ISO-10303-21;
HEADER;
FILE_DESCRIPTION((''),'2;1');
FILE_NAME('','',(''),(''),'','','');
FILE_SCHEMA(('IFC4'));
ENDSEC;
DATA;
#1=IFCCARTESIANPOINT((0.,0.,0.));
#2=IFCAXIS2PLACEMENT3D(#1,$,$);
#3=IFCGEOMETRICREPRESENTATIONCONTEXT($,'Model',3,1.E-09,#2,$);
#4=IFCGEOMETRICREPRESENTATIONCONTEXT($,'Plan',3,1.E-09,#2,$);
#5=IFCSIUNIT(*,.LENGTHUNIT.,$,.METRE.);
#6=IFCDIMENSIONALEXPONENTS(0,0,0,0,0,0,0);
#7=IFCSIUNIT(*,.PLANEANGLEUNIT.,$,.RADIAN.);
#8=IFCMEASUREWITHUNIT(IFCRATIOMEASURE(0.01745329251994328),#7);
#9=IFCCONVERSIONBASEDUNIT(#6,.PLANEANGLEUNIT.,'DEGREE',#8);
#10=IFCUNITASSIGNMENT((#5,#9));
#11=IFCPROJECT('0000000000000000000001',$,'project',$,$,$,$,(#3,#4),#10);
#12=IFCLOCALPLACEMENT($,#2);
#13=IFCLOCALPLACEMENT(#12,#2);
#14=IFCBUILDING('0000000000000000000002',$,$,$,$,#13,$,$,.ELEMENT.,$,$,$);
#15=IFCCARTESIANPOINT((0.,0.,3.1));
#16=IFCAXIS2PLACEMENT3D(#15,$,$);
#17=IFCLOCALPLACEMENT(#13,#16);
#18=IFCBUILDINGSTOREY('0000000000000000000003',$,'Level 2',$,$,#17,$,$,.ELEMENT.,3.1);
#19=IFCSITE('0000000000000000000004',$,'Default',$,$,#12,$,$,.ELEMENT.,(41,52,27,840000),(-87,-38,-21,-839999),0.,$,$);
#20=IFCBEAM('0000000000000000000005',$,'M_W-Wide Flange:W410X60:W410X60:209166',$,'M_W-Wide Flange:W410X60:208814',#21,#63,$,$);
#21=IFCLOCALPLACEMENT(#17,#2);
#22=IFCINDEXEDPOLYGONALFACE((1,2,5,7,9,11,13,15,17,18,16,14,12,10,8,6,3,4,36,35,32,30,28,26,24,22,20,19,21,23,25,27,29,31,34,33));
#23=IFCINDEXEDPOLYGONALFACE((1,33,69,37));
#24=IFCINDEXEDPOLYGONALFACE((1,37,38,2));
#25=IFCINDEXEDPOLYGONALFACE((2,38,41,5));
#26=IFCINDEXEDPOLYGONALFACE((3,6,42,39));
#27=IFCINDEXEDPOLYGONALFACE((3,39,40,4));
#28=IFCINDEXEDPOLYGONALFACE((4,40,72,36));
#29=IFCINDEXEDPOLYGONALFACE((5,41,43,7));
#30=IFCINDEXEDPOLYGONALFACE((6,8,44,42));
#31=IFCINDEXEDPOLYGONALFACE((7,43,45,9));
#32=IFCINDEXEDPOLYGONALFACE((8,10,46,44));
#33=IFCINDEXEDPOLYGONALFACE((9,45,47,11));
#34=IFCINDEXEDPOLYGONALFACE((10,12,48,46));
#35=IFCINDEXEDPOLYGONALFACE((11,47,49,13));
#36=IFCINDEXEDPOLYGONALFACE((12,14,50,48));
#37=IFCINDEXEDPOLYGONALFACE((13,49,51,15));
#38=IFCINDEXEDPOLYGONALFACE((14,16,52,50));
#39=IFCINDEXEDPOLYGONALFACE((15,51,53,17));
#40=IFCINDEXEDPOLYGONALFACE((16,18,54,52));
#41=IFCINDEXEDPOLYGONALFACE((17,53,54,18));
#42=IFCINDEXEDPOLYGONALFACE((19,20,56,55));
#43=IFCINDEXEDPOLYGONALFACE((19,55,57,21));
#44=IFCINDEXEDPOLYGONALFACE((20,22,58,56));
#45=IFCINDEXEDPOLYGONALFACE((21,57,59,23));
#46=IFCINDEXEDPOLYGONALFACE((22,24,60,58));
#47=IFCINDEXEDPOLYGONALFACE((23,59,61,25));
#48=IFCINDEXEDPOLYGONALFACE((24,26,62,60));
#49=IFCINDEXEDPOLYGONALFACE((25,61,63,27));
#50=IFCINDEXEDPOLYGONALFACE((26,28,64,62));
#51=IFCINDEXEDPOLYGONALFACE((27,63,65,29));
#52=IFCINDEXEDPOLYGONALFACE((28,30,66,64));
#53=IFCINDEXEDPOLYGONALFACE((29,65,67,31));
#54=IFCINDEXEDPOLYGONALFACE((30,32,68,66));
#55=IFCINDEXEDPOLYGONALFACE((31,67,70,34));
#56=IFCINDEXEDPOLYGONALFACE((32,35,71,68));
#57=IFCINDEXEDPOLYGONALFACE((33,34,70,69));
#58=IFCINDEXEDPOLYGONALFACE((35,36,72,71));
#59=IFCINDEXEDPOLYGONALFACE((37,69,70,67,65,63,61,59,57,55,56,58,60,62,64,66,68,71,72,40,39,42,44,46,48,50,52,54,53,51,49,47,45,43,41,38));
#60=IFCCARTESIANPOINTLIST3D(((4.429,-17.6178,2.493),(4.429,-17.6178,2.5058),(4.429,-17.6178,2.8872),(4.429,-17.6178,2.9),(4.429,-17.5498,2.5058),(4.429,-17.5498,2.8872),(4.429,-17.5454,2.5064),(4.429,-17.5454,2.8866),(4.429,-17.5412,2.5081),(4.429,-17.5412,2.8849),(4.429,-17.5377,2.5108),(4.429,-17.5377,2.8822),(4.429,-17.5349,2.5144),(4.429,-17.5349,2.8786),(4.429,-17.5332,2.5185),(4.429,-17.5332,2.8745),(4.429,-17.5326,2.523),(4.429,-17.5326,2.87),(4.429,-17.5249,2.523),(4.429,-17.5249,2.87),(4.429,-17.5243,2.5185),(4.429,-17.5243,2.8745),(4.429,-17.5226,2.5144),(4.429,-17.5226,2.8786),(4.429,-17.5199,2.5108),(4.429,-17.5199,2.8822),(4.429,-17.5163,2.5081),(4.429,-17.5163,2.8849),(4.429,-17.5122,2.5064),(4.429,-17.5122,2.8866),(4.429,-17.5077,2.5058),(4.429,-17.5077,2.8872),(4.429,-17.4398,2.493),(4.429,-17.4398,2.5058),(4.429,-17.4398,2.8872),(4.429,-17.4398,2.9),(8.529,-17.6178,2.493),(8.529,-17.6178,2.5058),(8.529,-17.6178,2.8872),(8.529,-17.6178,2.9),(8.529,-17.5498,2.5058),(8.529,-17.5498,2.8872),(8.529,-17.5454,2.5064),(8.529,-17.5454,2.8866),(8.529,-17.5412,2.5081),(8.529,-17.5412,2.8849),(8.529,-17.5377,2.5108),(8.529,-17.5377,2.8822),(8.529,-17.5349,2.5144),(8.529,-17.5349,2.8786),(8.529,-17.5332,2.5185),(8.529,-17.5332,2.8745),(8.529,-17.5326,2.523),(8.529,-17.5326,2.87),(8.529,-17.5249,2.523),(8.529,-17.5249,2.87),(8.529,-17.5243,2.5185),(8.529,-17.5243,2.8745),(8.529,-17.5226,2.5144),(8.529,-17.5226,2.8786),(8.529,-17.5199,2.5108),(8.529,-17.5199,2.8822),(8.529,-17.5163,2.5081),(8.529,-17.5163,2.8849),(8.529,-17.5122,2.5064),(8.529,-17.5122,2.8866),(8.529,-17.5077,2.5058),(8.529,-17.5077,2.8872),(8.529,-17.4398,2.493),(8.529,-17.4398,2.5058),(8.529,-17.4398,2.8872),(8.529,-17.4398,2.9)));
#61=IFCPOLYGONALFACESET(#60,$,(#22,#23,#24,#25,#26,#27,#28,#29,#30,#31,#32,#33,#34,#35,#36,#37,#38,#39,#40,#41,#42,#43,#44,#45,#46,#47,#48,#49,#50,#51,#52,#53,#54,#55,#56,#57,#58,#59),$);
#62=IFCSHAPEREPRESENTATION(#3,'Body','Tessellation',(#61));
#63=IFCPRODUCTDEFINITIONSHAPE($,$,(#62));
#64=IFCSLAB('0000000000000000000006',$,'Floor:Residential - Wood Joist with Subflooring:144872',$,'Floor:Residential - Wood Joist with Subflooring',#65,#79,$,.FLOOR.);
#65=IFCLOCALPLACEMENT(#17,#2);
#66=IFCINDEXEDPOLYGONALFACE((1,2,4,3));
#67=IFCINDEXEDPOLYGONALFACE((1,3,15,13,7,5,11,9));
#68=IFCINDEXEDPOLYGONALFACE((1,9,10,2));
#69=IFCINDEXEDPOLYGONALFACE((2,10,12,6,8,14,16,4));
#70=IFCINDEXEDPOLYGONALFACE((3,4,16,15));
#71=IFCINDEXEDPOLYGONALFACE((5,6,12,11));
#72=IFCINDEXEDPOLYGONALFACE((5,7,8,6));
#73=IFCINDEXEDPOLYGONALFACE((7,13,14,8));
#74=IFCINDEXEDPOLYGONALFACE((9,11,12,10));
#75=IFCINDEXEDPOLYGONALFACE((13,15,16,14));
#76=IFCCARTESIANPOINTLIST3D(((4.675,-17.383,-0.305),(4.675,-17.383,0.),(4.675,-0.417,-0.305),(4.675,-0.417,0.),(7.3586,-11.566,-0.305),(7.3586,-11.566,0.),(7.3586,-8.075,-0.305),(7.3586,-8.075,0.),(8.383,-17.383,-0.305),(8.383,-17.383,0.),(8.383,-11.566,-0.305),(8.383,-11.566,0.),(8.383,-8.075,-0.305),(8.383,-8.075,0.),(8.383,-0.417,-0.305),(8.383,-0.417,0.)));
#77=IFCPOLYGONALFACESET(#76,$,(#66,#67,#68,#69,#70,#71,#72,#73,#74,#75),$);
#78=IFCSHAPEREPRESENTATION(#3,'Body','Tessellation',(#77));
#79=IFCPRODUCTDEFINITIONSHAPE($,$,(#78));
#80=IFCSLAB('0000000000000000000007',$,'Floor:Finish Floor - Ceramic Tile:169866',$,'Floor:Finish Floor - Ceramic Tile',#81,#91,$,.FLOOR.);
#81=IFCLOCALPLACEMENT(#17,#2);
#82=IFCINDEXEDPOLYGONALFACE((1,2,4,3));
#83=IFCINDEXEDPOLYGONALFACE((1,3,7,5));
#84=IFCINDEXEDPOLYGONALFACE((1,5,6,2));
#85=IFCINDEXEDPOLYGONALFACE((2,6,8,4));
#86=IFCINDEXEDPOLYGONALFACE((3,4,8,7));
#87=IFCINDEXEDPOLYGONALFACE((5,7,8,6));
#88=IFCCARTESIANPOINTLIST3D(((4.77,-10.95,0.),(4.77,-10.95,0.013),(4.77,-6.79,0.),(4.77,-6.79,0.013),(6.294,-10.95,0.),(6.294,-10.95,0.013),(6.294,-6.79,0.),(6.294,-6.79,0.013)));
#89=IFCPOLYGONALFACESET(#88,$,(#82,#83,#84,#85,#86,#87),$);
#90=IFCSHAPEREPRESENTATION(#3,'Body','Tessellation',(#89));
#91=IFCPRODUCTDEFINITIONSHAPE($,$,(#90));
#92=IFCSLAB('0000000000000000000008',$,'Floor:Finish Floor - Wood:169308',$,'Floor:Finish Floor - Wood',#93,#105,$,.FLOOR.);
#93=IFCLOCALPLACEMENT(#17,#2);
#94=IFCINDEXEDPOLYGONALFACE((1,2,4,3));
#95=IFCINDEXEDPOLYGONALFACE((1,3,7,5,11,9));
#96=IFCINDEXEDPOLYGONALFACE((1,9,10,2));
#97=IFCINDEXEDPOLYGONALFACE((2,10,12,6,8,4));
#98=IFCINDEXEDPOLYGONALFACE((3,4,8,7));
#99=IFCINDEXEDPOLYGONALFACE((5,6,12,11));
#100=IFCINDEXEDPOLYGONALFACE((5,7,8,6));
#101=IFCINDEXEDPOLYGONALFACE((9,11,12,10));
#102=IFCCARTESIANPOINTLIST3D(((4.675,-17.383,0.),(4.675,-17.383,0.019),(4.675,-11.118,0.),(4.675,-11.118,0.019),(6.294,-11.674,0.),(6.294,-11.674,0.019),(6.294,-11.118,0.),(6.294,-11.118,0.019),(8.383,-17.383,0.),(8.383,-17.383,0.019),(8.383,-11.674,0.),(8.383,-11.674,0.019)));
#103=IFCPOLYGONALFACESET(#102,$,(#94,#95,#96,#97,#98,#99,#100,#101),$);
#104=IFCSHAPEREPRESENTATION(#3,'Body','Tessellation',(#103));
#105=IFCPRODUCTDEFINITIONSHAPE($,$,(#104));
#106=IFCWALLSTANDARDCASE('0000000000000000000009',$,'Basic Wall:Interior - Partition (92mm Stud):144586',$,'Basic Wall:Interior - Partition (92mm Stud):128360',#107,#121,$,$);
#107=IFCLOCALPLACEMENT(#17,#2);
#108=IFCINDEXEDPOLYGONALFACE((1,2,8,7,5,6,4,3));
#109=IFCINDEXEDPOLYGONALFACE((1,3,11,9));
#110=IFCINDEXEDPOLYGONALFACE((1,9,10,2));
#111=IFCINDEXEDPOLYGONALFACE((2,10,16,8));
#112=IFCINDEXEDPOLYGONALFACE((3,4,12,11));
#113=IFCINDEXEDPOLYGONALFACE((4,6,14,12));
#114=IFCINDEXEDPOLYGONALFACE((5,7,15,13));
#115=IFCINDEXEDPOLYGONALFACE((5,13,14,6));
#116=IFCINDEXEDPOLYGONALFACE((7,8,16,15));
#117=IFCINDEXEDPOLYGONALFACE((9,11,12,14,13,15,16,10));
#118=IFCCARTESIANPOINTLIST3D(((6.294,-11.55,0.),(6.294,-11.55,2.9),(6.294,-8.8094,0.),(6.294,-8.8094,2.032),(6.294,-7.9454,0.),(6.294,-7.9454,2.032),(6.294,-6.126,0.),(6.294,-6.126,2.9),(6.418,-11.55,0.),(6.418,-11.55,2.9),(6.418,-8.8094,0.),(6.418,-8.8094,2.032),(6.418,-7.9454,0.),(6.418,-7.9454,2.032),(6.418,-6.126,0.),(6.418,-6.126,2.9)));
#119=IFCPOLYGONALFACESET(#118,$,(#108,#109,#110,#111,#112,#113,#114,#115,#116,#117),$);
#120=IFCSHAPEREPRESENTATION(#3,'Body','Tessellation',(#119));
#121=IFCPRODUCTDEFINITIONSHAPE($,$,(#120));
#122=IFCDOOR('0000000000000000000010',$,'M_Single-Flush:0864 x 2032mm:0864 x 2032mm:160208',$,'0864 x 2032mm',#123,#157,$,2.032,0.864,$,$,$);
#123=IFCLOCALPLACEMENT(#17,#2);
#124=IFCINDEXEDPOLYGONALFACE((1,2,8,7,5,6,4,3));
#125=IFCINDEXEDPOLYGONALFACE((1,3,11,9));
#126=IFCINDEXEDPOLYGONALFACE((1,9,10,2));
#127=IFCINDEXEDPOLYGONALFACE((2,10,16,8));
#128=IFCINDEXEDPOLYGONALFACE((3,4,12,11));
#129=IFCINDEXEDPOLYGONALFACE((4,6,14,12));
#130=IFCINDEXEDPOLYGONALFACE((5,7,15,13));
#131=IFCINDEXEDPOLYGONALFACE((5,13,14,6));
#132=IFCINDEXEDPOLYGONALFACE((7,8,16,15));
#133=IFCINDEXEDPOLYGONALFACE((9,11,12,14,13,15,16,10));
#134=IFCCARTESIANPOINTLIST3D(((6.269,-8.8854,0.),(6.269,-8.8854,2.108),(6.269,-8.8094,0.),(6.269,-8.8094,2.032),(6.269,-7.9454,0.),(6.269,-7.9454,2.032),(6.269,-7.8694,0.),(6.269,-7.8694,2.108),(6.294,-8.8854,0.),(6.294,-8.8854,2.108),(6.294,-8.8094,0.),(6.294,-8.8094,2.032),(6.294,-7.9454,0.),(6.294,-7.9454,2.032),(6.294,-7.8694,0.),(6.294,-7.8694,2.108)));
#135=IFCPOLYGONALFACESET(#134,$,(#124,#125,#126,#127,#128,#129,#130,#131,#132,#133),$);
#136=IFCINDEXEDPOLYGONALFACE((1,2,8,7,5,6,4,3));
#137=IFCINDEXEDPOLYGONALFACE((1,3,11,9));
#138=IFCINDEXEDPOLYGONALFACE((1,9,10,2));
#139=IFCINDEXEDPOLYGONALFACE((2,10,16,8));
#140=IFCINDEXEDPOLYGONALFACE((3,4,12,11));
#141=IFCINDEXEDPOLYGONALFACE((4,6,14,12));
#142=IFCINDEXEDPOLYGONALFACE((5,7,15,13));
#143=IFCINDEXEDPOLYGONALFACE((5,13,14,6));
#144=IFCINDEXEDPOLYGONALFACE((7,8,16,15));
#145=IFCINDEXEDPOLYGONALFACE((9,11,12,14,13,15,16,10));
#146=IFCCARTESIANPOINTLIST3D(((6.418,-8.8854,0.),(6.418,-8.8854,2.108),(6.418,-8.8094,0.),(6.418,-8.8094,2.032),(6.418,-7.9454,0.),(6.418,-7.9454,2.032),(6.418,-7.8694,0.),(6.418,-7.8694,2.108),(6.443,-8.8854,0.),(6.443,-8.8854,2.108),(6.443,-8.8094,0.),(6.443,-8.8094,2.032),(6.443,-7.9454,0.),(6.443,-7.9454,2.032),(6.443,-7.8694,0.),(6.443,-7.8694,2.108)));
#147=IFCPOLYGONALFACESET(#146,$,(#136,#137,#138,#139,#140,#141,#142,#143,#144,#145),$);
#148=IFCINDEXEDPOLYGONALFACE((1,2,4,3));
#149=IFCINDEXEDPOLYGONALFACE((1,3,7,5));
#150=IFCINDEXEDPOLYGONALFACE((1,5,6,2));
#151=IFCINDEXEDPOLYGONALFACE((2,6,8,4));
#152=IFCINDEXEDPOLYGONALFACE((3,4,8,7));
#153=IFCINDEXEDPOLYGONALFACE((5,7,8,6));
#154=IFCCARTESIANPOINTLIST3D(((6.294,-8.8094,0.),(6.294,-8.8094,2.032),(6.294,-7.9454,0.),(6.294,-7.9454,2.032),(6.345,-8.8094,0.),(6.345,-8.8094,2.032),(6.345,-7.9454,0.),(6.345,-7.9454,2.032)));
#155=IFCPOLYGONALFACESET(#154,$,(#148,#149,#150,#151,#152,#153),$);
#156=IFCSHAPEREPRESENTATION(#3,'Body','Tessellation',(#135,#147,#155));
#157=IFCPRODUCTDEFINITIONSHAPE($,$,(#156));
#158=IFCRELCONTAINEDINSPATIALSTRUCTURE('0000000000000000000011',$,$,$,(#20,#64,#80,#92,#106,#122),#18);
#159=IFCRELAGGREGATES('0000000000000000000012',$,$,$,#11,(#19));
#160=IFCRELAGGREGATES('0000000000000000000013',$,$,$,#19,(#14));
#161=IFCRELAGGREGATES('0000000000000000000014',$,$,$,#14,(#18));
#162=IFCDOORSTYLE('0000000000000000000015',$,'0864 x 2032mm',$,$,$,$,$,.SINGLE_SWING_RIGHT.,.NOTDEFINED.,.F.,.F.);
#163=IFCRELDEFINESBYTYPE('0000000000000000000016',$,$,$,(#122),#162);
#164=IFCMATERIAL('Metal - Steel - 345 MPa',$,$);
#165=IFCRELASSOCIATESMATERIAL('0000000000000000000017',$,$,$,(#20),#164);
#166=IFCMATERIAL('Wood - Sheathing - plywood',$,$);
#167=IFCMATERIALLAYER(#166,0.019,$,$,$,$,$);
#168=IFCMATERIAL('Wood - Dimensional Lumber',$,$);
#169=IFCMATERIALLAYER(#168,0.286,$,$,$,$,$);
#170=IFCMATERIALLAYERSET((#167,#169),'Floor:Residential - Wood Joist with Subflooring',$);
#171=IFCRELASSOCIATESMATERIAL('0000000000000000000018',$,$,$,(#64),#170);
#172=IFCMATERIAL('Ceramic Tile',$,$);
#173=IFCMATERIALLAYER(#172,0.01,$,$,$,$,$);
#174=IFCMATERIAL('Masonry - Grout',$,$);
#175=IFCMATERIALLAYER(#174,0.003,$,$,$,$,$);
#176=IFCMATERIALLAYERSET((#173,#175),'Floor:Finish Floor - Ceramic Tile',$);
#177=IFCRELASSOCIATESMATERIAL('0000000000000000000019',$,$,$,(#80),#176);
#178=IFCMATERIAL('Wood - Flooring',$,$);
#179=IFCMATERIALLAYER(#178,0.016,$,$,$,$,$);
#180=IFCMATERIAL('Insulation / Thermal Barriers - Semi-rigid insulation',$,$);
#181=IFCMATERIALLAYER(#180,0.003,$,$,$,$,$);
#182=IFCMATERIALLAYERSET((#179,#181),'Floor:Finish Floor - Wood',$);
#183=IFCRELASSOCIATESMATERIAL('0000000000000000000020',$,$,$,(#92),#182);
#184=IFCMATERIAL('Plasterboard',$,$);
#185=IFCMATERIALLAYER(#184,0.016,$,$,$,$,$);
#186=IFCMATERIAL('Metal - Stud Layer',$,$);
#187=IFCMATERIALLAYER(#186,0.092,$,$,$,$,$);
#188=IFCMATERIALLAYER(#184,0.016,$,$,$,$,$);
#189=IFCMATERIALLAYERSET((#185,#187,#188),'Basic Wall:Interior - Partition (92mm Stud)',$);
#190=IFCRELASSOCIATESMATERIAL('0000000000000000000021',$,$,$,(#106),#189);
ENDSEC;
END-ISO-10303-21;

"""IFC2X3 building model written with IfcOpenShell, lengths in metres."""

from ifc_helpers import new_model, entity, si_unit, converted_unit, frame, frame_2d, origin, origin_2d_with_axis, place, context, project, spatial, polyline, circle_curve, parameter, trimmed, segment, composite_curve, rectangle, outline, extrude, source, transform, mapped, material, layer, layer_set, layer_usage, type_object, type_shapes, element, fill, save


model = new_model("IFC2X3")

# Units and contexts
model_context = context("Model", 3, precision=1e-09, world=origin())
plan_context = context("Plan", 3, precision=1e-09, world=origin())
ifc_project = project(units=[si_unit("LENGTHUNIT", "METRE"), converted_unit("PLANEANGLEUNIT", "DEGREE", entity("IfcRatioMeasure", 0.01745329251994328), si_unit("PLANEANGLEUNIT", "RADIAN"), dimensions=[0, 0, 0, 0, 0, 0, 0])], contexts=[model_context, plan_context])

# Site, building, storey
site_placement = place(None, origin())
site = spatial("IfcSite", under=ifc_project, at=site_placement, Name="Default", CompositionType="ELEMENT", RefLatitude=(41, 52, 27, 840000), RefLongitude=(-87, -38, -21, -839999), RefElevation=0.0)
building_placement = place(site_placement, origin())
building = spatial("IfcBuilding", under=site, at=building_placement, CompositionType="ELEMENT")
storey_placement = place(building_placement, frame((0.0, 0.0, 3.1)))
storey = spatial("IfcBuildingStorey", under=building, at=storey_placement, Name="Level 2", CompositionType="ELEMENT", Elevation=3.1)

# Beam
ifc_material_1 = material(Name="Metal - Steel - 345 MPa")
beam_placement = place(storey_placement, frame((4.429, -17.5288, 2.9), z_axis=(0.0, 0.0, 1.0), x_axis=(0.0, -1.0, 0.0)))
element("IfcBeam", 1, at=beam_placement, inside=storey, material=ifc_material_1, Name="M_W-Wide Flange:W410X60:W410X60:209166", ObjectType="M_W-Wide Flange:W410X60:208814", context=model_context, shape_type="SweptSolid", body=[
    extrude(outline(composite_curve([segment(polyline([(-0.089, -0.1907), (-0.089, -0.2035)]), True, "CONTINUOUS"), segment(polyline([(-0.089, -0.2035), (0.089, -0.2035)]), True, "CONTINUOUS"), segment(polyline([(0.089, -0.2035), (0.089, -0.1907)]), True, "CONTINUOUS"), segment(polyline([(0.089, -0.1907), (0.021, -0.1907)]), True, "CONTINUOUS"), segment(trimmed(circle_curve(frame_2d((0.021, -0.1735), x_axis=(0.0, -1.0)), 0.0172), [parameter(270.0)], [parameter(360.0)], True, "PARAMETER"), False, "CONTINUOUS"), segment(polyline([(0.0038, -0.1735), (0.0038, 0.1735)]), True, "CONTINUOUS"), segment(trimmed(circle_curve(frame_2d((0.021, 0.1735), x_axis=(-1.0, 0.0)), 0.0172), [parameter(270.0)], [parameter(360.0)], True, "PARAMETER"), False, "CONTINUOUS"), segment(polyline([(0.021, 0.1907), (0.089, 0.1907)]), True, "CONTINUOUS"), segment(polyline([(0.089, 0.1907), (0.089, 0.2035)]), True, "CONTINUOUS"), segment(polyline([(0.089, 0.2035), (-0.089, 0.2035)]), True, "CONTINUOUS"), segment(polyline([(-0.089, 0.2035), (-0.089, 0.1907)]), True, "CONTINUOUS"), segment(polyline([(-0.089, 0.1907), (-0.0211, 0.1907)]), True, "CONTINUOUS"), segment(trimmed(circle_curve(frame_2d((-0.0211, 0.1735), x_axis=(0.0, 1.0)), 0.0172), [parameter(270.0)], [parameter(0.0)], True, "PARAMETER"), False, "CONTINUOUS"), segment(polyline([(-0.0039, 0.1735), (-0.0039, -0.1735)]), True, "CONTINUOUS"), segment(trimmed(circle_curve(frame_2d((-0.0211, -0.1735), x_axis=(1.0, 0.0)), 0.0172), [parameter(270.0)], [parameter(0.0)], True, "PARAMETER"), False, "CONTINUOUS"), segment(polyline([(-0.0211, -0.1907), (-0.089, -0.1907)]), True, "CONTINUOUS")], self_intersect=False)), frame((0.0, 0.0, -0.2035), z_axis=(0.0, -1.0, 0.0), x_axis=(1.0, 0.0, 0.0)), (0.0, 0.0, -1.0), 4.1),
])

# Slabs
ifc_material_2 = material(Name="Wood - Sheathing - plywood")
ifc_layer_1 = layer(ifc_material_2, 0.019)
ifc_material_3 = material(Name="Wood - Dimensional Lumber")
ifc_layer_2 = layer(ifc_material_3, 0.286)
ifc_layer_set_1 = layer_set([ifc_layer_1, ifc_layer_2], Name="Floor:Residential - Wood Joist with Subflooring")
ifc_layer_usage_1 = layer_usage(ifc_layer_set_1, "AXIS3", "POSITIVE", 0.0)
slab_1_placement = place(storey_placement, frame((4.675, -17.383, -0.305)))
element("IfcSlab", 2, at=slab_1_placement, inside=storey, material=ifc_layer_usage_1, Name="Floor:Residential - Wood Joist with Subflooring:144872", ObjectType="Floor:Residential - Wood Joist with Subflooring", PredefinedType="FLOOR", context=model_context, shape_type="SweptSolid", body=[
    extrude(outline(polyline([(-1.854, 8.483), (-1.854, 0.825), (-0.8296, 0.825), (-0.8296, -2.666), (-1.854, -2.666), (-1.854, -8.483), (1.854, -8.483), (1.854, 8.483), (-1.854, 8.483)])), frame((1.854, 8.483, 0.305), z_axis=(0.0, 0.0, -1.0), x_axis=(-1.0, 0.0, 0.0)), (0.0, 0.0, 1.0), 0.305),
])
ifc_material_4 = material(Name="Ceramic Tile")
ifc_layer_3 = layer(ifc_material_4, 0.01)
ifc_material_5 = material(Name="Masonry - Grout")
ifc_layer_4 = layer(ifc_material_5, 0.003)
ifc_layer_set_2 = layer_set([ifc_layer_3, ifc_layer_4], Name="Floor:Finish Floor - Ceramic Tile")
ifc_layer_usage_2 = layer_usage(ifc_layer_set_2, "AXIS3", "POSITIVE", 0.0)
slab_2_placement = place(storey_placement, frame((4.77, -10.95, 0.0)))
element("IfcSlab", 3, at=slab_2_placement, inside=storey, material=ifc_layer_usage_2, Name="Floor:Finish Floor - Ceramic Tile:169866", ObjectType="Floor:Finish Floor - Ceramic Tile", PredefinedType="FLOOR", context=model_context, shape_type="SweptSolid", body=[
    extrude(rectangle(XDim=4.16, YDim=1.524, at=frame_2d((0.0, 0.0), x_axis=(0.0, -1.0))), frame((0.762, 2.08, 0.013), z_axis=(0.0, 0.0, -1.0), x_axis=(-1.0, 0.0, 0.0)), (0.0, 0.0, 1.0), 0.013),
])
ifc_material_6 = material(Name="Wood - Flooring")
ifc_layer_5 = layer(ifc_material_6, 0.016)
ifc_material_7 = material(Name="Insulation / Thermal Barriers - Semi-rigid insulation")
ifc_layer_6 = layer(ifc_material_7, 0.003)
ifc_layer_set_3 = layer_set([ifc_layer_5, ifc_layer_6], Name="Floor:Finish Floor - Wood")
ifc_layer_usage_3 = layer_usage(ifc_layer_set_3, "AXIS3", "POSITIVE", 0.0)
slab_3_placement = place(storey_placement, frame((4.675, -17.383, 0.0)))
element("IfcSlab", 4, at=slab_3_placement, inside=storey, material=ifc_layer_usage_3, Name="Floor:Finish Floor - Wood:169308", ObjectType="Floor:Finish Floor - Wood", PredefinedType="FLOOR", context=model_context, shape_type="SweptSolid", body=[
    extrude(outline(polyline([(-1.854, 2.5765), (-1.854, -3.1325), (1.854, -3.1325), (1.854, 3.1325), (0.235, 3.1325), (0.235, 2.5765), (-1.854, 2.5765)])), frame((1.854, 3.1325, 0.019), z_axis=(0.0, 0.0, -1.0), x_axis=(-1.0, 0.0, 0.0)), (0.0, 0.0, 1.0), 0.019),
])

# Wall, opening, door
ifc_material_8 = material(Name="Plasterboard")
ifc_layer_7 = layer(ifc_material_8, 0.016)
ifc_material_9 = material(Name="Metal - Stud Layer")
ifc_layer_8 = layer(ifc_material_9, 0.092)
ifc_layer_9 = layer(ifc_material_8, 0.016)
ifc_layer_set_4 = layer_set([ifc_layer_7, ifc_layer_8, ifc_layer_9], Name="Basic Wall:Interior - Partition (92mm Stud)")
ifc_layer_usage_4 = layer_usage(ifc_layer_set_4, "AXIS2", "NEGATIVE", 0.062)
wall_1_placement = place(storey_placement, frame((6.356, -11.55, 0.0), z_axis=(0.0, 0.0, 1.0), x_axis=(0.0, 1.0, 0.0)))
wall_1 = element("IfcWallStandardCase", 5, at=wall_1_placement, inside=storey, material=ifc_layer_usage_4, Name="Basic Wall:Interior - Partition (92mm Stud):144586", ObjectType="Basic Wall:Interior - Partition (92mm Stud):128360", context=model_context, shape_type="SweptSolid", body=[
    extrude(rectangle(XDim=5.424, YDim=0.124, at=frame_2d((2.712, 0.0), x_axis=(-1.0, 0.0))), origin(), (0.0, 0.0, 1.0), 2.9),
])
opening_1_placement = place(wall_1_placement, frame((2.7406, -0.062, 0.0)))
opening_1 = element("IfcOpeningElement", 6, at=opening_1_placement, cuts=wall_1, ObjectType="Opening", context=model_context, shape_type="SweptSolid", body=[
    extrude(rectangle(XDim=0.864, YDim=2.032, at=frame_2d((1.016, 0.432), x_axis=(0.0, 1.0))), frame((0.0, 0.0, 0.0), z_axis=(0.0, 1.0, 0.0), x_axis=(0.0, 0.0, 1.0)), (0.0, 0.0, 1.0), 0.124),
])
door_style = type_object("IfcDoorStyle", Name="0864 x 2032mm", ConstructionType="NOTDEFINED", OperationType="SINGLE_SWING_RIGHT", ParameterTakesPrecedence=False, Sizeable=False)
shared_shape_1 = source(origin(), model_context, "Body", "SweptSolid", [
    extrude(outline(polyline([(-0.508, -1.073), (0.508, -1.073), (0.508, 1.035), (0.432, 1.035), (0.432, -0.997), (-0.432, -0.997), (-0.432, 1.035), (-0.508, 1.035), (-0.508, -1.073)])), frame((0.432, 0.124, 1.035), z_axis=(0.0, 1.0, 0.0), x_axis=(1.0, 0.0, 0.0)), (0.0, 0.0, 1.0), 0.025),
    extrude(outline(polyline([(-1.073, -0.508), (1.035, -0.508), (1.035, -0.432), (-0.997, -0.432), (-0.997, 0.432), (1.035, 0.432), (1.035, 0.508), (-1.073, 0.508), (-1.073, -0.508)])), frame((0.432, -0.025, 1.035), z_axis=(0.0, 1.0, 0.0), x_axis=(0.0, 0.0, -1.0)), (0.0, 0.0, 1.0), 0.025),
    extrude(rectangle(XDim=0.051, YDim=0.864, at=origin_2d_with_axis()), frame((0.432, 0.0985, 0.0), z_axis=(0.0, 0.0, 1.0), x_axis=(0.0, 1.0, 0.0)), (0.0, 0.0, 1.0), 2.032),
])
type_shapes(door_style, [shared_shape_1])
door_placement = place(opening_1_placement, origin())
door = element("IfcDoor", 7, at=door_placement, inside=storey, type_object=door_style, Name="M_Single-Flush:0864 x 2032mm:0864 x 2032mm:160208", ObjectType="0864 x 2032mm", OverallHeight=2.032, OverallWidth=0.864, context=model_context, shape_type="MappedRepresentation", body=[
    mapped(shared_shape_1, transform((0.0, 0.0, 0.0), scale=1.0)),
])
fill(opening_1, door)

save(model, "model.ifc")
